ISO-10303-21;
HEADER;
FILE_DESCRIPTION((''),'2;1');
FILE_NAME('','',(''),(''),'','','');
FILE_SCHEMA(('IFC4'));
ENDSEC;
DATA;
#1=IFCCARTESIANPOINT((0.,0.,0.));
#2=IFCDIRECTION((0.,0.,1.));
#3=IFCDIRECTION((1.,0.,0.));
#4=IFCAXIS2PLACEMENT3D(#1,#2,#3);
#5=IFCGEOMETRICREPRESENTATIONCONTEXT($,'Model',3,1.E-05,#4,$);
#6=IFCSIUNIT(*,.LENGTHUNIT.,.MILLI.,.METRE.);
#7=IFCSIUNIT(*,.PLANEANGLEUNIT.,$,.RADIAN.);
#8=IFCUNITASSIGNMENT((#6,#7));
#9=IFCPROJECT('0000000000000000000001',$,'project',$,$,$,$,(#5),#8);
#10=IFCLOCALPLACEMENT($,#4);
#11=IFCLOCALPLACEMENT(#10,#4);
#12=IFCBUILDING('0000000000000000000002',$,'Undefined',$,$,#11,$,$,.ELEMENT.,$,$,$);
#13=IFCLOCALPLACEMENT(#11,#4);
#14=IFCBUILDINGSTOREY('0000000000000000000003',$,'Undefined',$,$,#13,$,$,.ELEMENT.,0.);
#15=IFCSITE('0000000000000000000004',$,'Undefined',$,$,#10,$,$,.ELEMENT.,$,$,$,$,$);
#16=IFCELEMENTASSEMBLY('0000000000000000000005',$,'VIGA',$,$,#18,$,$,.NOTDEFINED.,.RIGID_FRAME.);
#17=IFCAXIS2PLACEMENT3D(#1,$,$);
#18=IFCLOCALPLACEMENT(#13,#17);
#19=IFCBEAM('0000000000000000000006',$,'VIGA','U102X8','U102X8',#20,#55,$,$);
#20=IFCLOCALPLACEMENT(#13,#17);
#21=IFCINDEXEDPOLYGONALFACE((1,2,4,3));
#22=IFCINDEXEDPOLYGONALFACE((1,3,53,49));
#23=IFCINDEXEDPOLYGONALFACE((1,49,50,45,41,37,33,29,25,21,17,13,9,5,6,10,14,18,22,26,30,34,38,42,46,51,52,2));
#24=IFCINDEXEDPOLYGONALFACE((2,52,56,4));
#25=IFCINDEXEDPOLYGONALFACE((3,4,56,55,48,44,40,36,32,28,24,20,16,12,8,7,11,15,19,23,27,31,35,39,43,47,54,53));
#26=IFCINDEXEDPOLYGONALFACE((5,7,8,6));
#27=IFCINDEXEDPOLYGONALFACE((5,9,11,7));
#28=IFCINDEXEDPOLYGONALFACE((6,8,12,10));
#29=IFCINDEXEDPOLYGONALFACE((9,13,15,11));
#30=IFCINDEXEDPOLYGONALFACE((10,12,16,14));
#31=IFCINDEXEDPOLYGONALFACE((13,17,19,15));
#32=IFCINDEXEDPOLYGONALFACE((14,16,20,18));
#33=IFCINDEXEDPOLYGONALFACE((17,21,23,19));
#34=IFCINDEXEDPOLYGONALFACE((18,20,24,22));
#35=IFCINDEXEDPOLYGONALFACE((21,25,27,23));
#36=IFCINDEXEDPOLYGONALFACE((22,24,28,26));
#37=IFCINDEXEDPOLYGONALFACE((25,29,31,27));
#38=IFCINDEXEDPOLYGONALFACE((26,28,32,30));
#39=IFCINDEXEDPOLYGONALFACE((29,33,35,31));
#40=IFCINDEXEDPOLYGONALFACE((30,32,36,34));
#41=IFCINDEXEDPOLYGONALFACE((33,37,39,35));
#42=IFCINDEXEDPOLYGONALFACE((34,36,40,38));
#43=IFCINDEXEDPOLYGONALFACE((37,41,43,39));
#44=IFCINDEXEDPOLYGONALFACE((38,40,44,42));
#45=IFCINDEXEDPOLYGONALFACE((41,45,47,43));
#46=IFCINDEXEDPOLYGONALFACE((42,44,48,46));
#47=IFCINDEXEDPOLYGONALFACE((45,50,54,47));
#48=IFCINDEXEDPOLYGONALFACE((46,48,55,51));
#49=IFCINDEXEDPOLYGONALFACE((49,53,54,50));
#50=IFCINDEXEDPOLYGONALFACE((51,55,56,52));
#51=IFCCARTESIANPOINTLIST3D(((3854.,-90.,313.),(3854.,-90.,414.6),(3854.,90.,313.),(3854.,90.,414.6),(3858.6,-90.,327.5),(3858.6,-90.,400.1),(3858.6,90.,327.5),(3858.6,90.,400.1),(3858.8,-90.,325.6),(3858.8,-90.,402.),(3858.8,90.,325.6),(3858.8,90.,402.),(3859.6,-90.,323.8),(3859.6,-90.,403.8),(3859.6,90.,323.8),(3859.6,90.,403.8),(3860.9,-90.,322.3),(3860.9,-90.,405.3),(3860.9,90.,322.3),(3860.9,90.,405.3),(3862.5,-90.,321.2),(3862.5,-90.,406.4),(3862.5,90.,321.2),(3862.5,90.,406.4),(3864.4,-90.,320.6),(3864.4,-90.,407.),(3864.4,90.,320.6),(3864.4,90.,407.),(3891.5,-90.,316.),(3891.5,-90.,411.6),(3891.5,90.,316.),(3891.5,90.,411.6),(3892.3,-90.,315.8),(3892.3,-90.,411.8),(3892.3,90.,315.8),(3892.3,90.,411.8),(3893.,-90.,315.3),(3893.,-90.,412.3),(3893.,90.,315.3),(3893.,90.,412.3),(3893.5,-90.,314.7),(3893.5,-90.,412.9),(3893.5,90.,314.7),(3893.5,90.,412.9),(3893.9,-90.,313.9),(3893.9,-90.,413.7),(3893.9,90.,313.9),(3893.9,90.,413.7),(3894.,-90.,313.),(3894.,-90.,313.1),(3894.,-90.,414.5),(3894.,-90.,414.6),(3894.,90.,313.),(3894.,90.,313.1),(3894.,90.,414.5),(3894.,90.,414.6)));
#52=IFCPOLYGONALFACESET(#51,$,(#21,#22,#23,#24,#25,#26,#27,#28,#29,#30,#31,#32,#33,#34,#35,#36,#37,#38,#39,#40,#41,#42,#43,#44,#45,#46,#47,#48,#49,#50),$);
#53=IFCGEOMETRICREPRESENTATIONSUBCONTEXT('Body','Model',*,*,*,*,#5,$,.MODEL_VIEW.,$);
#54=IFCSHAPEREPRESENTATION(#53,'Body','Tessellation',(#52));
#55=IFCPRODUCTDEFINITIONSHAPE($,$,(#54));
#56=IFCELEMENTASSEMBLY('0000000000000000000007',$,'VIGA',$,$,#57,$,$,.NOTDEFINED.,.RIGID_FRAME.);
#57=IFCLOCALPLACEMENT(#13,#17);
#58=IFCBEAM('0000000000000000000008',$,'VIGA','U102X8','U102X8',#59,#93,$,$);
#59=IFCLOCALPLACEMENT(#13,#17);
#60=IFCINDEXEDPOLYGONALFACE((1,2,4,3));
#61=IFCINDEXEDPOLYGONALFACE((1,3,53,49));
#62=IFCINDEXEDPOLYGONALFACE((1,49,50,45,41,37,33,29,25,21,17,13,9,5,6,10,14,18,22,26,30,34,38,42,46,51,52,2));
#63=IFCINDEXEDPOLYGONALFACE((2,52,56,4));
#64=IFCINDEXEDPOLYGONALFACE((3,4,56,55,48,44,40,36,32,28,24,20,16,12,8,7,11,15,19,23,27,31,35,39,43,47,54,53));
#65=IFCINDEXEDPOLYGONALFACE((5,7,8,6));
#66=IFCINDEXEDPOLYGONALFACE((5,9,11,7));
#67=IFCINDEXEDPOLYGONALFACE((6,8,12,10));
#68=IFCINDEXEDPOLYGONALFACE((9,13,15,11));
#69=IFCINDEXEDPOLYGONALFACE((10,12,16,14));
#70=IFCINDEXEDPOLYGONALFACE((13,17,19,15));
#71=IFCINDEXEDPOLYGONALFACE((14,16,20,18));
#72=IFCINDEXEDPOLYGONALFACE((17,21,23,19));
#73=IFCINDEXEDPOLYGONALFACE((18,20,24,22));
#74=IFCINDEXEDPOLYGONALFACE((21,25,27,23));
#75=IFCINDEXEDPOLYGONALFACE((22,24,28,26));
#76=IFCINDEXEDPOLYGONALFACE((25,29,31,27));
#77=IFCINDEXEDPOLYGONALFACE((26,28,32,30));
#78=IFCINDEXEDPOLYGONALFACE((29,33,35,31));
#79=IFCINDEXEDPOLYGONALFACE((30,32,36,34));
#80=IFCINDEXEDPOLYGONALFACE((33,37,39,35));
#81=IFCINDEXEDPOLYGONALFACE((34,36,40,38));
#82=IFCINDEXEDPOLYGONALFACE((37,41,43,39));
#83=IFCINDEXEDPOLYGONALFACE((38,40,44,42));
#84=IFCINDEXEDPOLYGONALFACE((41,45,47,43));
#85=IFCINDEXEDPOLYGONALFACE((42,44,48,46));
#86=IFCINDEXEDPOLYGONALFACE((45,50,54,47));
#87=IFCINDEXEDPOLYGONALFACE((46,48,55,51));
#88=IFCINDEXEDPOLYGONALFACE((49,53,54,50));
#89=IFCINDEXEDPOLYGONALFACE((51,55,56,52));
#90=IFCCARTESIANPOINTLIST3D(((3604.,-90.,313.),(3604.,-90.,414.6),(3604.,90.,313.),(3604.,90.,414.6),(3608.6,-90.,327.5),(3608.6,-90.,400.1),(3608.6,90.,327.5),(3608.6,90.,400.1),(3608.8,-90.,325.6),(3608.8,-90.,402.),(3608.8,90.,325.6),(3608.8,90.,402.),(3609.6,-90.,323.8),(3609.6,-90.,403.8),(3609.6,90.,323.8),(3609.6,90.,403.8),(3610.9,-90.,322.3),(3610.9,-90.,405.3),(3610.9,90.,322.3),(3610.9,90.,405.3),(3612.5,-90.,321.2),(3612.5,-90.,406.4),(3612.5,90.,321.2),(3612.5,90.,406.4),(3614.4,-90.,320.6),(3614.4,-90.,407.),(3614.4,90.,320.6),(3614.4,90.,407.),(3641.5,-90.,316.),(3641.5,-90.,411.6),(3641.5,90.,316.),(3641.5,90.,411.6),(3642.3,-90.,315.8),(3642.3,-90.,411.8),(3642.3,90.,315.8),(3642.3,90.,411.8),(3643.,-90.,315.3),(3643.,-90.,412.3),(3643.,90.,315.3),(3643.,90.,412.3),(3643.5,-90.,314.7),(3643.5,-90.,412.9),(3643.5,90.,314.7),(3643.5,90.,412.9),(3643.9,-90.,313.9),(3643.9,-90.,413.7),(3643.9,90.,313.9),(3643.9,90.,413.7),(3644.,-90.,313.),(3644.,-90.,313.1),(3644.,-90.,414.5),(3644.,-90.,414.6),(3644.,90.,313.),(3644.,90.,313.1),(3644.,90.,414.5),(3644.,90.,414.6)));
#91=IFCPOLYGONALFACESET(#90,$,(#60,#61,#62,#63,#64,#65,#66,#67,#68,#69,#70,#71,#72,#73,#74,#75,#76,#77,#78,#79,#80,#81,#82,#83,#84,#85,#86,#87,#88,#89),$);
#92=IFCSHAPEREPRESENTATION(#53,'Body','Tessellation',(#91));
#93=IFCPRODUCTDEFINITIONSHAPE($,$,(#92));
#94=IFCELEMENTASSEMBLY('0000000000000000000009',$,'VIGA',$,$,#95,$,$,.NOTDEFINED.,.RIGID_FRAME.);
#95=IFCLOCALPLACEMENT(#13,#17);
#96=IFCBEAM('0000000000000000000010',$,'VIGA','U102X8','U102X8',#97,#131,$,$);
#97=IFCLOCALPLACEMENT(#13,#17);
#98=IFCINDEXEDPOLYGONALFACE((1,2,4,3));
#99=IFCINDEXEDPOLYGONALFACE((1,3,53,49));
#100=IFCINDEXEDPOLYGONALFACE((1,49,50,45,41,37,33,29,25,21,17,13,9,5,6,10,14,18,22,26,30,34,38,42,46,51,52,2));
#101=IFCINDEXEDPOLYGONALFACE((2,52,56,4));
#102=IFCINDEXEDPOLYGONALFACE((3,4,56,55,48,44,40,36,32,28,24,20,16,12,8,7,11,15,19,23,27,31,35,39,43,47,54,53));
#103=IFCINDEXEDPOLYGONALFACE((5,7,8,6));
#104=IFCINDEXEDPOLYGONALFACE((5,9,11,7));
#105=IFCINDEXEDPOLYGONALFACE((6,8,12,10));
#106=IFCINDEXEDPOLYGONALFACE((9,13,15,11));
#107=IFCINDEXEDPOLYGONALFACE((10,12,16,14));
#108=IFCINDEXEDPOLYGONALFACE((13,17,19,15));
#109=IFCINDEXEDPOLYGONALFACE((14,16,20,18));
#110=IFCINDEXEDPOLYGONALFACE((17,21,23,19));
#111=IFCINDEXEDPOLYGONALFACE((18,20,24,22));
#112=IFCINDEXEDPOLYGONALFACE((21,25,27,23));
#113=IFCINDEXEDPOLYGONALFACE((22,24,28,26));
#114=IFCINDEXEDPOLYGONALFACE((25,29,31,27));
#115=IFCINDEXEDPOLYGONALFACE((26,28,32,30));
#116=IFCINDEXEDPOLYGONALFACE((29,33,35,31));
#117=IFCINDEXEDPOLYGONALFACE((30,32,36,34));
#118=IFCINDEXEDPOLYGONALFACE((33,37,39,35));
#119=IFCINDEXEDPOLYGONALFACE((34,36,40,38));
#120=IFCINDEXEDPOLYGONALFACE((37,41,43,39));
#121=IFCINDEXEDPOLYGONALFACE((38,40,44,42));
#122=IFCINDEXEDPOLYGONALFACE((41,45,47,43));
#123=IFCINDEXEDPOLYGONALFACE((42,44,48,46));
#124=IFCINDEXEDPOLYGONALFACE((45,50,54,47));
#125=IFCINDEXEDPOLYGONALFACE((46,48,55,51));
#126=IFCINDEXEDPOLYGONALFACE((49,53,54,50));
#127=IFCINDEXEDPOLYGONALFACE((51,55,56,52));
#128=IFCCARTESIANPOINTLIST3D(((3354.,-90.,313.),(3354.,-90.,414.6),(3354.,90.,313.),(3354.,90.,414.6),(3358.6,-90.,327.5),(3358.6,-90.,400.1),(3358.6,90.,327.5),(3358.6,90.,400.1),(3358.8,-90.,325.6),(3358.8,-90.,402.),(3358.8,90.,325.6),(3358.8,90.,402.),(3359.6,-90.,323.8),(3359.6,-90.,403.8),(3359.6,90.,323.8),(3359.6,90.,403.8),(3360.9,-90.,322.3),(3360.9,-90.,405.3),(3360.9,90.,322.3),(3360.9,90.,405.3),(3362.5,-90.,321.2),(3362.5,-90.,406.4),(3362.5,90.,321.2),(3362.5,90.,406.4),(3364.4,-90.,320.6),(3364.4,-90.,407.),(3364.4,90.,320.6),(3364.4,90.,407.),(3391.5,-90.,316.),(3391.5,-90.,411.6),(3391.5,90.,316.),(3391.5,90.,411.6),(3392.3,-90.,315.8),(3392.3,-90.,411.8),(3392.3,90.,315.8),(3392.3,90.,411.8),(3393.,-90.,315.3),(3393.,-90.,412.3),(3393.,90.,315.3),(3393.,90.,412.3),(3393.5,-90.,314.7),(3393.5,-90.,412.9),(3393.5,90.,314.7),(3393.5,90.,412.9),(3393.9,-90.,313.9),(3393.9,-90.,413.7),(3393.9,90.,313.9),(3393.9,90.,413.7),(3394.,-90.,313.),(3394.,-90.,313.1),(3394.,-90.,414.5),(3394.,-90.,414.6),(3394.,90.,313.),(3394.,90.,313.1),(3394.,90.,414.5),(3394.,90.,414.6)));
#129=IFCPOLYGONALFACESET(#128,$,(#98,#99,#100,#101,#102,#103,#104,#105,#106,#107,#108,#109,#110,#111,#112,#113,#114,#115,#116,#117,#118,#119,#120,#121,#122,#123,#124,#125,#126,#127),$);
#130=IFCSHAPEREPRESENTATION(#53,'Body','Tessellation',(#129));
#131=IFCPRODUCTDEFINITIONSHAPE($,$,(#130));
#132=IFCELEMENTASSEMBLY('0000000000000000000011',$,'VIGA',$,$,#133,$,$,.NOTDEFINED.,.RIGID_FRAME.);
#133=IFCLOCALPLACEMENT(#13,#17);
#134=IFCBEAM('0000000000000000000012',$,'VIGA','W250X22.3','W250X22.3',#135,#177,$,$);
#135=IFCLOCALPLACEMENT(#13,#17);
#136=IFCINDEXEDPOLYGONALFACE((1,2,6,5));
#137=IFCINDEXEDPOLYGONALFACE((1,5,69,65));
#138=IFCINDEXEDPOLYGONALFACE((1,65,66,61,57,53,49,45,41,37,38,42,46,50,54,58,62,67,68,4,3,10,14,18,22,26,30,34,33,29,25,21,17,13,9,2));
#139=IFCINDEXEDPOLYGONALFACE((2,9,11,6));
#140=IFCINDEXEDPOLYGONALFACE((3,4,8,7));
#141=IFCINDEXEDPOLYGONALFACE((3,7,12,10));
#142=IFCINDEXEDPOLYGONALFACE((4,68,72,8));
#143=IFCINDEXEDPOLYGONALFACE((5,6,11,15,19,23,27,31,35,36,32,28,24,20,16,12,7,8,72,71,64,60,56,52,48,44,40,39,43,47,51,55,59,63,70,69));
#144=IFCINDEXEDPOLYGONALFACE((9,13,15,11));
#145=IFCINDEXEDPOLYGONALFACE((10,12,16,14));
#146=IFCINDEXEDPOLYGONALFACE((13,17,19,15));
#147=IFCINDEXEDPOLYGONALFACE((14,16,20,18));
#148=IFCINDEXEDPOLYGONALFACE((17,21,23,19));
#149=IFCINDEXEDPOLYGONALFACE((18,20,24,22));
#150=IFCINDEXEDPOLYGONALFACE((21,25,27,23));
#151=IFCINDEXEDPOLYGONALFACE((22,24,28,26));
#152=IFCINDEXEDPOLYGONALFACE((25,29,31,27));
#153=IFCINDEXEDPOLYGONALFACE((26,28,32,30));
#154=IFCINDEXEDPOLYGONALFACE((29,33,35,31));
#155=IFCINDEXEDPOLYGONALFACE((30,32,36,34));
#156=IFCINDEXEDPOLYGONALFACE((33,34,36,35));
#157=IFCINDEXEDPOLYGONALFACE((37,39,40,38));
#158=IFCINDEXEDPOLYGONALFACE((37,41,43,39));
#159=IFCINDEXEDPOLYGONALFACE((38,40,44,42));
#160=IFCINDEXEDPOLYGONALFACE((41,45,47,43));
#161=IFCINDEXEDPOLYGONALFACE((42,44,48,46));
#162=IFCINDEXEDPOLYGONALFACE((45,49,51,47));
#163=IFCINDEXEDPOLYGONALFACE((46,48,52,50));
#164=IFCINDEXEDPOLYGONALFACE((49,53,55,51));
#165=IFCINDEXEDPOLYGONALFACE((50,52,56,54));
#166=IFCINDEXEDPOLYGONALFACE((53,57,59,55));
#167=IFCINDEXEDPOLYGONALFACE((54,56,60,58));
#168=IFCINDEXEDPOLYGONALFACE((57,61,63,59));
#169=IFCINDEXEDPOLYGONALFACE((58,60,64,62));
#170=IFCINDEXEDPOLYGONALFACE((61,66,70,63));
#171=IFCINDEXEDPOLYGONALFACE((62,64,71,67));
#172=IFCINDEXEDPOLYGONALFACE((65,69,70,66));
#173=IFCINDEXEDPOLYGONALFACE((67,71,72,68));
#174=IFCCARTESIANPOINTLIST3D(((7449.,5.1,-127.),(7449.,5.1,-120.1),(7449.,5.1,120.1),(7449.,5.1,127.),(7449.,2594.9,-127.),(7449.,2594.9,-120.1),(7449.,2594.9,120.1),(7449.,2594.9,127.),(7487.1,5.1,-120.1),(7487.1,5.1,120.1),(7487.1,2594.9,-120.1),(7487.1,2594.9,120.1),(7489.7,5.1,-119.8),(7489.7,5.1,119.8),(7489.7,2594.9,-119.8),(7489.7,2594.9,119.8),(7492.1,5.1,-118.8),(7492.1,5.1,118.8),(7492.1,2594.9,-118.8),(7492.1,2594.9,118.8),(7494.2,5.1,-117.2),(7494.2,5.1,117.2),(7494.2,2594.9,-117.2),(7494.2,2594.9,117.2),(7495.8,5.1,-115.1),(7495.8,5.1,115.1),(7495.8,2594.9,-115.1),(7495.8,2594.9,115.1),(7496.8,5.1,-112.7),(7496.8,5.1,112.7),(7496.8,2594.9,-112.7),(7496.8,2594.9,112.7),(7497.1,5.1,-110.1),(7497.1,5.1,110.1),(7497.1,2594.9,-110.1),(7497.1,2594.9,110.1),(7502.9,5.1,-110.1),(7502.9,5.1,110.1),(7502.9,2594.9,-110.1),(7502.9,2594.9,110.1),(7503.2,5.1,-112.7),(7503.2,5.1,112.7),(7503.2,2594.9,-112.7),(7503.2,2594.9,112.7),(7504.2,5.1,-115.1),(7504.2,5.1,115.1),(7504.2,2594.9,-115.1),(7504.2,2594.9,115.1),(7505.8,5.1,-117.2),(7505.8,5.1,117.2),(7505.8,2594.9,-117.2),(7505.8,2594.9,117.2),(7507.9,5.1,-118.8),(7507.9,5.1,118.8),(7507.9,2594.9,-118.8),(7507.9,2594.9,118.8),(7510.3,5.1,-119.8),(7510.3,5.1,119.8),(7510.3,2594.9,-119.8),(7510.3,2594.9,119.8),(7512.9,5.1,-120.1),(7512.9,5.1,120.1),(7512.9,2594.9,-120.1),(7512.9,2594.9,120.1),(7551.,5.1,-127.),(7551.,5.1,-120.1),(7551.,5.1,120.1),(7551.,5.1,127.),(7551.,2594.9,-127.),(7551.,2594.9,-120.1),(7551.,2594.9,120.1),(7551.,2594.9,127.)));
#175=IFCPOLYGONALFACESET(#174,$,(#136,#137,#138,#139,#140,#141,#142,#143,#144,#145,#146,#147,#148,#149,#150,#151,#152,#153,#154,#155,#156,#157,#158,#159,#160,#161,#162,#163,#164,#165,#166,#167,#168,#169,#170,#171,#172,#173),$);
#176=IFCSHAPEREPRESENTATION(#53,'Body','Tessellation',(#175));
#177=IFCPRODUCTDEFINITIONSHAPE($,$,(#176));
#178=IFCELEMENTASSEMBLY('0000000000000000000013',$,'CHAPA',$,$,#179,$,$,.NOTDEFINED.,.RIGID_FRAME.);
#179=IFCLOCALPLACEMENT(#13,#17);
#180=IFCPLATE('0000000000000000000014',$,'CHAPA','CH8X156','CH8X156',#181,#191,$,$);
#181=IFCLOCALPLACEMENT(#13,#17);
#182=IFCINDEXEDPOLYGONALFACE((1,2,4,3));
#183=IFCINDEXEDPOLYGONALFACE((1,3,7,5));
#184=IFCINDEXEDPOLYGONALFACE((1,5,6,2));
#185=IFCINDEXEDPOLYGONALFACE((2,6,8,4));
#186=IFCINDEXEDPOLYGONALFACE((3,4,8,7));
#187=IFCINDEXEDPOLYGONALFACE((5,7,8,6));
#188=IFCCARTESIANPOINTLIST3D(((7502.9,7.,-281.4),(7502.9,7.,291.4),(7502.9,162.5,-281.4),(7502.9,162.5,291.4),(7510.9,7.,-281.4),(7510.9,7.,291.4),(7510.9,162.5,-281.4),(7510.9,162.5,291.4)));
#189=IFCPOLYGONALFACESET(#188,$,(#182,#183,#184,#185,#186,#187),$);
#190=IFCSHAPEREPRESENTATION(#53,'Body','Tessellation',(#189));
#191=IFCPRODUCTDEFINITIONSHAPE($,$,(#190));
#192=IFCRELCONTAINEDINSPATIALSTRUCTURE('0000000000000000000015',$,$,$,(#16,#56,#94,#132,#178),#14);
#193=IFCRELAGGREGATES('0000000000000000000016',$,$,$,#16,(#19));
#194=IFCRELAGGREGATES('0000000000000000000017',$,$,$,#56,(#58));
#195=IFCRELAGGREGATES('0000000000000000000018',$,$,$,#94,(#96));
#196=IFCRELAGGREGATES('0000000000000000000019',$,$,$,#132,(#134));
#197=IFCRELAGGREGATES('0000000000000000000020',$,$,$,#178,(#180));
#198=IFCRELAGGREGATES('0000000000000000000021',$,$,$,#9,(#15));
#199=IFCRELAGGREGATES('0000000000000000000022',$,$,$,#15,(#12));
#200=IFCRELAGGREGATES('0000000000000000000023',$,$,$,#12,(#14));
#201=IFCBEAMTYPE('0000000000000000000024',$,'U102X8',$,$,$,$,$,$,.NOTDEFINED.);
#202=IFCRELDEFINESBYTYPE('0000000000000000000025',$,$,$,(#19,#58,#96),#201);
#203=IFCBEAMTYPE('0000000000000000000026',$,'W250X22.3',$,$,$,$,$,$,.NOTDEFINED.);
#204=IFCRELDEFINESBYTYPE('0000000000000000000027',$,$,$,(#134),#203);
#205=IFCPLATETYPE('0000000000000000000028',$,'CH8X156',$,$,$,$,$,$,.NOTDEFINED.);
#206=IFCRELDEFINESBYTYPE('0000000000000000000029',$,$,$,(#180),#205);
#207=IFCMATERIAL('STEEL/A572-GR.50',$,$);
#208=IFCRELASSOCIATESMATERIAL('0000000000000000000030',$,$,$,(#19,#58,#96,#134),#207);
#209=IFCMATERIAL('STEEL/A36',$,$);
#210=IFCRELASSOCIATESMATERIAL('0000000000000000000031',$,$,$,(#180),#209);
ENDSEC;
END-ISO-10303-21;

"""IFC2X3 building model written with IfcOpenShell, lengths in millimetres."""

from ifc_helpers import new_model, si_unit, frame, origin_with_axes, origin_2d_with_axis, place, context, subcontext, project, spatial, polyline, i_section, u_section, outline, extrude, material, type_object, element, aggregate, save


model = new_model("IFC2X3")

# Units and contexts
model_context = context("Model", 3, precision=1e-05, world=origin_with_axes())
body_context = subcontext(model_context, "Body", "Model", "MODEL_VIEW")
ifc_project = project(units=[si_unit("LENGTHUNIT", "METRE", prefix="MILLI"), si_unit("PLANEANGLEUNIT", "RADIAN")], contexts=[model_context])

# Site, building, storey
site_placement = place(None, origin_with_axes())
site = spatial("IfcSite", under=ifc_project, at=site_placement, Name="Undefined", CompositionType="ELEMENT")
building_placement = place(site_placement, origin_with_axes())
building = spatial("IfcBuilding", under=site, at=building_placement, Name="Undefined", CompositionType="ELEMENT")
storey_placement = place(building_placement, origin_with_axes())
storey = spatial("IfcBuildingStorey", under=building, at=storey_placement, Name="Undefined", CompositionType="ELEMENT", Elevation=0.0)

# Element assemblies, beams
ifc_material_1 = material(Name="STEEL/A572-GR.50")
beam_type_1 = type_object("IfcBeamType", Name="U102X8", PredefinedType="NOTDEFINED")
assembly_1_placement = place(storey_placement, origin_with_axes())
assembly_1 = element("IfcElementAssembly", 1, at=assembly_1_placement, inside=storey, Name="VIGA", AssemblyPlace="NOTDEFINED", PredefinedType="RIGID_FRAME")
beam_1_placement = place(assembly_1_placement, frame((3874.0, -90.0, 363.8), z_axis=(0.0, 0.0, 1.0), x_axis=(0.0, 1.0, 0.0)))
beam_1 = element("IfcBeam", 2, at=beam_1_placement, type_object=beam_type_1, material=ifc_material_1, Name="VIGA", Description="U102X8", ObjectType="U102X8", context=body_context, shape_type="SweptSolid", body=[
    extrude(u_section(Depth=101.6, FlangeWidth=40.0, WebThickness=4.6, FlangeThickness=6.0, FilletRadius=7.0, EdgeRadius=3.0, FlangeSlope=0.16839, at=origin_2d_with_axis()), frame((180.0, 0.0, 0.0), z_axis=(-1.0, 0.0, 0.0), x_axis=(0.0, -1.0, 0.0)), (0.0, 0.0, 1.0), 180.0),
])
aggregate(assembly_1, [beam_1])
assembly_2_placement = place(storey_placement, origin_with_axes())
assembly_2 = element("IfcElementAssembly", 3, at=assembly_2_placement, inside=storey, Name="VIGA", AssemblyPlace="NOTDEFINED", PredefinedType="RIGID_FRAME")
beam_2_placement = place(assembly_2_placement, frame((3624.0, -90.0, 363.8), z_axis=(0.0, 0.0, 1.0), x_axis=(0.0, 1.0, 0.0)))
beam_2 = element("IfcBeam", 4, at=beam_2_placement, type_object=beam_type_1, material=ifc_material_1, Name="VIGA", Description="U102X8", ObjectType="U102X8", context=body_context, shape_type="SweptSolid", body=[
    extrude(u_section(Depth=101.6, FlangeWidth=40.0, WebThickness=4.6, FlangeThickness=6.0, FilletRadius=7.0, EdgeRadius=3.0, FlangeSlope=0.16839, at=origin_2d_with_axis()), frame((180.0, 0.0, 0.0), z_axis=(-1.0, 0.0, 0.0), x_axis=(0.0, -1.0, 0.0)), (0.0, 0.0, 1.0), 180.0),
])
aggregate(assembly_2, [beam_2])
assembly_3_placement = place(storey_placement, origin_with_axes())
assembly_3 = element("IfcElementAssembly", 5, at=assembly_3_placement, inside=storey, Name="VIGA", AssemblyPlace="NOTDEFINED", PredefinedType="RIGID_FRAME")
beam_3_placement = place(assembly_3_placement, frame((3374.0, -90.0, 363.8), z_axis=(0.0, 0.0, 1.0), x_axis=(0.0, 1.0, 0.0)))
beam_3 = element("IfcBeam", 6, at=beam_3_placement, type_object=beam_type_1, material=ifc_material_1, Name="VIGA", Description="U102X8", ObjectType="U102X8", context=body_context, shape_type="SweptSolid", body=[
    extrude(u_section(Depth=101.6, FlangeWidth=40.0, WebThickness=4.6, FlangeThickness=6.0, FilletRadius=7.0, EdgeRadius=3.0, FlangeSlope=0.16839, at=origin_2d_with_axis()), frame((180.0, 0.0, 0.0), z_axis=(-1.0, 0.0, 0.0), x_axis=(0.0, -1.0, 0.0)), (0.0, 0.0, 1.0), 180.0),
])
aggregate(assembly_3, [beam_3])
assembly_4_placement = place(storey_placement, origin_with_axes())
assembly_4 = element("IfcElementAssembly", 7, at=assembly_4_placement, inside=storey, Name="VIGA", AssemblyPlace="NOTDEFINED", PredefinedType="RIGID_FRAME")
beam_type_2 = type_object("IfcBeamType", Name="W250X22.3", PredefinedType="NOTDEFINED")
beam_4_placement = place(assembly_4_placement, frame((7500.0, 5.1, 0.0), z_axis=(0.0, 0.0, 1.0), x_axis=(0.0, 1.0, 0.0)))
beam_4 = element("IfcBeam", 8, at=beam_4_placement, type_object=beam_type_2, material=ifc_material_1, Name="VIGA", Description="W250X22.3", ObjectType="W250X22.3", context=body_context, shape_type="SweptSolid", body=[
    extrude(i_section(OverallWidth=102.0, OverallDepth=254.0, WebThickness=5.8, FlangeThickness=6.9, FilletRadius=10.0, at=origin_2d_with_axis()), frame((2589.8, 0.0, 0.0), z_axis=(-1.0, 0.0, 0.0), x_axis=(0.0, -1.0, 0.0)), (0.0, 0.0, 1.0), 2589.8),
])
aggregate(assembly_4, [beam_4])

# Element assembly, plate
assembly_5_placement = place(storey_placement, origin_with_axes())
assembly_5 = element("IfcElementAssembly", 9, at=assembly_5_placement, inside=storey, Name="CHAPA", AssemblyPlace="NOTDEFINED", PredefinedType="RIGID_FRAME")
ifc_material_2 = material(Name="STEEL/A36")
plate_type = type_object("IfcPlateType", Name="CH8X156", PredefinedType="NOTDEFINED")
plate_placement = place(assembly_5_placement, frame((7506.9, 162.5, 291.4), z_axis=(1.0, 0.0, 0.0), x_axis=(0.0, -1.0, 0.0)))
plate = element("IfcPlate", 10, at=plate_placement, type_object=plate_type, material=ifc_material_2, Name="CHAPA", Description="CH8X156", ObjectType="CH8X156", context=body_context, shape_type="SweptSolid", body=[
    extrude(outline(polyline([(0.0, 0.0), (155.5, 0.0), (155.5, 572.8), (0.0, 572.8), (0.0, 0.0)])), frame((0.0, 0.0, -4.0), z_axis=(0.0, 0.0, 1.0), x_axis=(1.0, 0.0, 0.0)), (0.0, 0.0, 1.0), 8.0),
])
aggregate(assembly_5, [plate])

save(model, "model.ifc")
